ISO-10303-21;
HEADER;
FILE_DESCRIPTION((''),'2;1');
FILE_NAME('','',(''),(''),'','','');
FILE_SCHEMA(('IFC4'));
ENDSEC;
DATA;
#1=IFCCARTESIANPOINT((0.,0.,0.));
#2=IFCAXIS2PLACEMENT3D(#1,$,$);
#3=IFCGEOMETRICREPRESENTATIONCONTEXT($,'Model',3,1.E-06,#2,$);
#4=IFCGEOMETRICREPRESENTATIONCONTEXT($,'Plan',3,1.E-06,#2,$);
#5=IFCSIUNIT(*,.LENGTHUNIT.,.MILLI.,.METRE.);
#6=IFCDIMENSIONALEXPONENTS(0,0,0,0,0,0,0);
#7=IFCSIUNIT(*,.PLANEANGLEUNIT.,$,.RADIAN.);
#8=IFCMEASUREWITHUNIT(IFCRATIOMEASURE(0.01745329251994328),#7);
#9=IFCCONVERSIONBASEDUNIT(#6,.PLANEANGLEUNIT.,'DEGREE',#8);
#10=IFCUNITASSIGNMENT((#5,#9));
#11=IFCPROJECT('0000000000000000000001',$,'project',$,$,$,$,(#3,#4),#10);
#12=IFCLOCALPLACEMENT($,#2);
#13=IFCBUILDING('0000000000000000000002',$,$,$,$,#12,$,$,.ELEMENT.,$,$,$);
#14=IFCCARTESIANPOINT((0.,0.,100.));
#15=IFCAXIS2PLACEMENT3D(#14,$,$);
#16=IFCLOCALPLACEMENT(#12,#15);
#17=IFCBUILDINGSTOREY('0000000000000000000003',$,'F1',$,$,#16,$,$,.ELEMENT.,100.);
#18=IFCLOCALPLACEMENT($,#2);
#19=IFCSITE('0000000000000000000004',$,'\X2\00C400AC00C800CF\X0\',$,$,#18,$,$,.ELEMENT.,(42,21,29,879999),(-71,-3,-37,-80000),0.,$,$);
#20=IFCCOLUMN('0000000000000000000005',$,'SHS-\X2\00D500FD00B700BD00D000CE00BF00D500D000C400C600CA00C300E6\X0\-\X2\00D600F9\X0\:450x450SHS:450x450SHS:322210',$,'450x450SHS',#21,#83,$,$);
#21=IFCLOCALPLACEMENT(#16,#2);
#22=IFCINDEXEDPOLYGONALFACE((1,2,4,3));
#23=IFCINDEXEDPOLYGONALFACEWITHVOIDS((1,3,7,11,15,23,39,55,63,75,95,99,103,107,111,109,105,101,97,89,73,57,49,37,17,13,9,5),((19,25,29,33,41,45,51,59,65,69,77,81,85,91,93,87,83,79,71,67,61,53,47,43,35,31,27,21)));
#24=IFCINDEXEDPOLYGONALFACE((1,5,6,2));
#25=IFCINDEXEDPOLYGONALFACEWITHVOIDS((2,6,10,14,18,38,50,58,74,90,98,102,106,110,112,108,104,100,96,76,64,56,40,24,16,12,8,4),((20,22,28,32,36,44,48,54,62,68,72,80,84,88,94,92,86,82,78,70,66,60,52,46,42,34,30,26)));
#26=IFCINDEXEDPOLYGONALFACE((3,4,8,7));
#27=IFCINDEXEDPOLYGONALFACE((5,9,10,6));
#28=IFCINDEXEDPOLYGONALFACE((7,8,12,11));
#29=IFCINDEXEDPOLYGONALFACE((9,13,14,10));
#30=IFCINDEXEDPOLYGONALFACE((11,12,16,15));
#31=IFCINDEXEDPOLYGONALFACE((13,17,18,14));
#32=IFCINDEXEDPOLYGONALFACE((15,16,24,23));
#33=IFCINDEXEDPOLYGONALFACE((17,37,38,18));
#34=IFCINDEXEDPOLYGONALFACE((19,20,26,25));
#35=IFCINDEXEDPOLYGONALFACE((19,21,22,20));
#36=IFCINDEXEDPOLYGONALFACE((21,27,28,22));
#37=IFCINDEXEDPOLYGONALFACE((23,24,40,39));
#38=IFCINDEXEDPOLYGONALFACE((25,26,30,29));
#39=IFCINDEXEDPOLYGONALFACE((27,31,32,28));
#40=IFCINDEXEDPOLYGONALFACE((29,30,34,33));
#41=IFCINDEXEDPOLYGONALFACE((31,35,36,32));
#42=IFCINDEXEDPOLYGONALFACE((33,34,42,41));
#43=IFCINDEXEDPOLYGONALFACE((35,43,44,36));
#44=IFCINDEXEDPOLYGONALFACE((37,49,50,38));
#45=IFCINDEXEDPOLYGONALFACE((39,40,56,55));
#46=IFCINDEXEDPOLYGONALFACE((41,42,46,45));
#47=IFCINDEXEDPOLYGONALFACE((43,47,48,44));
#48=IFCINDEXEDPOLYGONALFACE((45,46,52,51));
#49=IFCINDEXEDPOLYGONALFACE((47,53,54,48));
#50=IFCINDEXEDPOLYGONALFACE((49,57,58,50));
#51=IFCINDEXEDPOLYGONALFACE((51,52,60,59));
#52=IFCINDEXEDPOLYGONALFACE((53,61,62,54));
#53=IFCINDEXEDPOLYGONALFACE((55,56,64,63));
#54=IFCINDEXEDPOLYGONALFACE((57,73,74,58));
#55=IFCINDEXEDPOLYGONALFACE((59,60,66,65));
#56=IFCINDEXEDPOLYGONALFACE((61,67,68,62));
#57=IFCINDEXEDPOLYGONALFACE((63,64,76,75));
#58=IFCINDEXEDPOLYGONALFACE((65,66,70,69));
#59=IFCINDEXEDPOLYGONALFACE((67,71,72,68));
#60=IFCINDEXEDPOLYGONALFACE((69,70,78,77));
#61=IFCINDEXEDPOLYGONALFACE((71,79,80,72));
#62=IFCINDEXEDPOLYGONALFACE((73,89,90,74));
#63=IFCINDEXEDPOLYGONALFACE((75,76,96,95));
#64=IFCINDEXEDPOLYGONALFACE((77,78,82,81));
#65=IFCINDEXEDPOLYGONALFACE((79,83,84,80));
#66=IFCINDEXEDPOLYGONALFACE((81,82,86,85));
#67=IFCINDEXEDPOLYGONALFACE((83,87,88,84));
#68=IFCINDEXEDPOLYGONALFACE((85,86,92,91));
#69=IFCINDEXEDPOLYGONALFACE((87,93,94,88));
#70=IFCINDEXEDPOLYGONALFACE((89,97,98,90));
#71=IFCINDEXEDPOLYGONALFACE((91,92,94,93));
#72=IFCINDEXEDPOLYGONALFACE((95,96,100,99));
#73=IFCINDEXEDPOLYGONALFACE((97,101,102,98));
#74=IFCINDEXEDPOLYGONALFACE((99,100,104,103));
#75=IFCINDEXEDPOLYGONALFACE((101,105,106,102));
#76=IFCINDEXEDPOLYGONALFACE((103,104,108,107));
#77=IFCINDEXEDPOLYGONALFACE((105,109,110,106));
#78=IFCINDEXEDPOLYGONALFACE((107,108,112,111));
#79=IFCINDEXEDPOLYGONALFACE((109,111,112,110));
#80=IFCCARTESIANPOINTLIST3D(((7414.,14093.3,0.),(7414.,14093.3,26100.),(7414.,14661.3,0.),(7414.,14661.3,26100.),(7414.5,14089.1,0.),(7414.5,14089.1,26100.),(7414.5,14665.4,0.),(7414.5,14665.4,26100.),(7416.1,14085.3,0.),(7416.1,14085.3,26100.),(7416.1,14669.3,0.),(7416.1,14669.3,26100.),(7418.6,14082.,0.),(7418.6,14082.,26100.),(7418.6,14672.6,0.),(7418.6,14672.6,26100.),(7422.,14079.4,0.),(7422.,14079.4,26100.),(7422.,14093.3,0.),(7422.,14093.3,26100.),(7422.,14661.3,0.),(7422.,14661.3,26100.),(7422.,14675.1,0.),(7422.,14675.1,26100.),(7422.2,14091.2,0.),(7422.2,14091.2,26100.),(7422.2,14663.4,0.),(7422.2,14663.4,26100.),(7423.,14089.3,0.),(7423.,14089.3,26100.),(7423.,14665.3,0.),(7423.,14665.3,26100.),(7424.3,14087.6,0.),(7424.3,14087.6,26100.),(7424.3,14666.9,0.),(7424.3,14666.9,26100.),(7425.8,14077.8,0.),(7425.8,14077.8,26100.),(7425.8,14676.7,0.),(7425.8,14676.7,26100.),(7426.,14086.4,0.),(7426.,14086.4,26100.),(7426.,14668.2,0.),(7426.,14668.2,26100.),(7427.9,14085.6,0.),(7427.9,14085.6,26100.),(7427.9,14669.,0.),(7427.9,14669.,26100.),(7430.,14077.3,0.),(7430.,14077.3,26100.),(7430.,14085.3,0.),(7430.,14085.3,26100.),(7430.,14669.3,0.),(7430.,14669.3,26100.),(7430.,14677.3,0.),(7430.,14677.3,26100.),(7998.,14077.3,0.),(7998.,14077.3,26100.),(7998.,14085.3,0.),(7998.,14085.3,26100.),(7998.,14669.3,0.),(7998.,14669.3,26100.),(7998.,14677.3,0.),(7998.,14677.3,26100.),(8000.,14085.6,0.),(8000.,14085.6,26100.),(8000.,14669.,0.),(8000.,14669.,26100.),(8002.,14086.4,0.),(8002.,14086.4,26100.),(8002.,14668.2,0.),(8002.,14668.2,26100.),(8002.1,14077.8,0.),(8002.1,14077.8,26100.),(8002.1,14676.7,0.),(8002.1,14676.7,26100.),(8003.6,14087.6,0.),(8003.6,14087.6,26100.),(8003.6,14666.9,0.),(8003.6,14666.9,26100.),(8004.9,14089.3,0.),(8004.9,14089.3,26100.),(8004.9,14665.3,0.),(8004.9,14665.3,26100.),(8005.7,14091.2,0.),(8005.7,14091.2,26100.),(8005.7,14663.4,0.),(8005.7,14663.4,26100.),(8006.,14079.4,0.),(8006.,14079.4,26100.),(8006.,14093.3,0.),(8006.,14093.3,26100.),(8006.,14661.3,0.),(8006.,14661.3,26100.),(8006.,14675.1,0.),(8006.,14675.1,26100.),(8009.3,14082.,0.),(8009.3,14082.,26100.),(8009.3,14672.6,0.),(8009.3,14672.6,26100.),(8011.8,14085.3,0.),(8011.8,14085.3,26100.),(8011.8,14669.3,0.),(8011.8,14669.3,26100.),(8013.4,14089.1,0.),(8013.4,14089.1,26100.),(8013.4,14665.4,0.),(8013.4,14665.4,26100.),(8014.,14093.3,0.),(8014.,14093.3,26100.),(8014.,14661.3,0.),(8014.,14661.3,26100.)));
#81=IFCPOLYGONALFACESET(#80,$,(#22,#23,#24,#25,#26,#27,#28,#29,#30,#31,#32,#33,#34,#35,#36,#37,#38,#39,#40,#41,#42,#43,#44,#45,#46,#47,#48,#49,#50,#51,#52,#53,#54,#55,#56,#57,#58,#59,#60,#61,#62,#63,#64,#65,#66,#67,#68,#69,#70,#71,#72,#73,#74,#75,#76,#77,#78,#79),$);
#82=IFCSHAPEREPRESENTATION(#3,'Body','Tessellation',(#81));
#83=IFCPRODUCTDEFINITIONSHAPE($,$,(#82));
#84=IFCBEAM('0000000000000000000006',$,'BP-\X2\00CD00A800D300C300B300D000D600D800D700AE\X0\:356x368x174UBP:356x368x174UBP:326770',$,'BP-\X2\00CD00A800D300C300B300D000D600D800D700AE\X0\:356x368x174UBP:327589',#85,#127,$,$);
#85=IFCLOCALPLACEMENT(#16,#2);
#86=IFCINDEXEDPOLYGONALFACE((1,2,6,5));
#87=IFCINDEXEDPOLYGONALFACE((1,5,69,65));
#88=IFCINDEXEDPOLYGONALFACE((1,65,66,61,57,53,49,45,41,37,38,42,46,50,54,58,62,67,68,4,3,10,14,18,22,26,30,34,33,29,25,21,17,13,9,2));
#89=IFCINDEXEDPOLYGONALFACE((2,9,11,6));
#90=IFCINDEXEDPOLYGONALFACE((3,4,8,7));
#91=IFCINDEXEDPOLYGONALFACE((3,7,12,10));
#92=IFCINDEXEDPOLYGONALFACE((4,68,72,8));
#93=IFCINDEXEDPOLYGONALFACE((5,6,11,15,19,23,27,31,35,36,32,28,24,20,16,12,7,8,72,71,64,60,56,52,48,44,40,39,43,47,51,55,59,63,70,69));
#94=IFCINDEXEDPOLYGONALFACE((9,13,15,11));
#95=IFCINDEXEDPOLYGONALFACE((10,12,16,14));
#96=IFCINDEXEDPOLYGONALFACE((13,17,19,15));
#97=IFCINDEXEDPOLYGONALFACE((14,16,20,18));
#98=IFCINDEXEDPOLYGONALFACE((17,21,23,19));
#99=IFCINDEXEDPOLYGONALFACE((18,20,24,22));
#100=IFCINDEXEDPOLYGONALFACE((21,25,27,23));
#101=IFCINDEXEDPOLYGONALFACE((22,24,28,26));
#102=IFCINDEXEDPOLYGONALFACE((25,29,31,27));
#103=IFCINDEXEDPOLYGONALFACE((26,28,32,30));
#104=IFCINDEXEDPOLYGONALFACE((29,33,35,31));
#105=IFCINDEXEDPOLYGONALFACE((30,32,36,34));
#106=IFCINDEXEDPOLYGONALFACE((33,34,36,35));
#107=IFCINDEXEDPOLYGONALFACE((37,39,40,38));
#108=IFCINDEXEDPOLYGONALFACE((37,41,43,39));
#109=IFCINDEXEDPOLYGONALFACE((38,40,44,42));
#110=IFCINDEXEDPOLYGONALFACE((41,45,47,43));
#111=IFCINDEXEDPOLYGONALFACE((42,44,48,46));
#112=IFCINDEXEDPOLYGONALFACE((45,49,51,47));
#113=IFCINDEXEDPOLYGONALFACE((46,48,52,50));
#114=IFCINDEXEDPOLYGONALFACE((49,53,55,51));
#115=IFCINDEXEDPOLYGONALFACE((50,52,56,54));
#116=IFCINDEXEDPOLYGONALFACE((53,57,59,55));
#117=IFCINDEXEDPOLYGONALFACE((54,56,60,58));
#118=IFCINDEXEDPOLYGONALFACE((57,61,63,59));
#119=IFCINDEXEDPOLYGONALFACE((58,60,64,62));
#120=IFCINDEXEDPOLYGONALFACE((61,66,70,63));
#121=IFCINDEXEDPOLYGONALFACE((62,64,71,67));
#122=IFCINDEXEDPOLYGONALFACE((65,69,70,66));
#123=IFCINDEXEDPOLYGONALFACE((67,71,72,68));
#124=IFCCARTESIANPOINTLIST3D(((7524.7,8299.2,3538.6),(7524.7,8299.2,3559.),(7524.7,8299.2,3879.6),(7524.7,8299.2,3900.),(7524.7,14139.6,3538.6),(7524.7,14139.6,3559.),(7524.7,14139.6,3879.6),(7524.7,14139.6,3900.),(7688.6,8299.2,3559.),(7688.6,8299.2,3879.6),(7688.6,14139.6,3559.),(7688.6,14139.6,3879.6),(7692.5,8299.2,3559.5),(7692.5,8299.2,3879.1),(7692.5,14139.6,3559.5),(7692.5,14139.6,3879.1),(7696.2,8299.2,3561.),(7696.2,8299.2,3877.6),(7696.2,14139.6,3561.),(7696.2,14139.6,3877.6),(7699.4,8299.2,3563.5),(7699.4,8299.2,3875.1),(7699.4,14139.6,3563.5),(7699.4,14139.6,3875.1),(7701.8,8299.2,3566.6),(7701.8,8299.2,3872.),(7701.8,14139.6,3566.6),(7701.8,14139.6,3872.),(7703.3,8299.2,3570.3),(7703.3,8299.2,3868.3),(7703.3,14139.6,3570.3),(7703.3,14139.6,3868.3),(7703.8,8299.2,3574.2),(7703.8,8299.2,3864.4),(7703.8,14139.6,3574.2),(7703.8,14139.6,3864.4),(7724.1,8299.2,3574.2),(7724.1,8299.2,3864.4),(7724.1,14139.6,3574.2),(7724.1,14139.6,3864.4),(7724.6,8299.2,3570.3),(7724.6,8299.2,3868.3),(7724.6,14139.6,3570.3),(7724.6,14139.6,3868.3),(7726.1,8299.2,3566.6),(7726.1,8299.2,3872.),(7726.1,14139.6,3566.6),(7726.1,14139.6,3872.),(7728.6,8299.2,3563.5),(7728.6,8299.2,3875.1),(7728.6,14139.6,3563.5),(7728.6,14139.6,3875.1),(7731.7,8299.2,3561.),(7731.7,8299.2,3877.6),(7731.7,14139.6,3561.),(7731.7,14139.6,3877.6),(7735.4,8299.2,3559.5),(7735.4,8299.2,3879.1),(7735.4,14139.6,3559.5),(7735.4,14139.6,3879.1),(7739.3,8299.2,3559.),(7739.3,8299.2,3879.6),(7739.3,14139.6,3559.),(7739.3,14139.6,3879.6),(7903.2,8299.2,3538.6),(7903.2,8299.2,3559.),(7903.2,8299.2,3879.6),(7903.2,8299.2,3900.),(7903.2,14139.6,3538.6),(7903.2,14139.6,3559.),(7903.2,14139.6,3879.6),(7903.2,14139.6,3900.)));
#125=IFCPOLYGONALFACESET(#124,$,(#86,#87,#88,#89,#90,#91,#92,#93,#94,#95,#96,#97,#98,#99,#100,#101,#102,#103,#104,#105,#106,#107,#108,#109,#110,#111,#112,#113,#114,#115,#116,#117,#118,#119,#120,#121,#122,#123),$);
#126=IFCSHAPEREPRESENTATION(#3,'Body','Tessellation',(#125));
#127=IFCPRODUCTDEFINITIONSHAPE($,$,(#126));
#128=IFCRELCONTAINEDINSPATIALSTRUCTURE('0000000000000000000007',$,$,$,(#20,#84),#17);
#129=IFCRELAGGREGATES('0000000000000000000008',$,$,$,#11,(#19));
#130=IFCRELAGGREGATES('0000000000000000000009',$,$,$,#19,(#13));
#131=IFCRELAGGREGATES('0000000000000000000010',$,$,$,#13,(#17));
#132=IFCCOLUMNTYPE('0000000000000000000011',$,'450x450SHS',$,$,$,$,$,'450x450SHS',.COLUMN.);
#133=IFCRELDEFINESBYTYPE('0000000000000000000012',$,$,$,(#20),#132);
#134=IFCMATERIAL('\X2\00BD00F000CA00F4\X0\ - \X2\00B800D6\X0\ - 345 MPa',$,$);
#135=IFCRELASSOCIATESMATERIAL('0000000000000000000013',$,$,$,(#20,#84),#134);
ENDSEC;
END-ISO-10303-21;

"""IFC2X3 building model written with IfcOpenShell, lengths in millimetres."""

from ifc_helpers import new_model, entity, si_unit, converted_unit, frame, frame_2d, origin, place, context, project, spatial, polyline, circle_curve, parameter, trimmed, segment, composite_curve, outline, extrude, source, transform, mapped, material, type_object, type_shapes, element, save


model = new_model("IFC2X3")

# Units and contexts
model_context = context("Model", 3, precision=1e-06, world=origin())
plan_context = context("Plan", 3, precision=1e-06, world=origin())
ifc_project = project(units=[si_unit("LENGTHUNIT", "METRE", prefix="MILLI"), converted_unit("PLANEANGLEUNIT", "DEGREE", entity("IfcRatioMeasure", 0.01745329251994328), si_unit("PLANEANGLEUNIT", "RADIAN"), dimensions=[0, 0, 0, 0, 0, 0, 0])], contexts=[model_context, plan_context])

# Site, building, storey
site_placement = place(None, origin())
site = spatial("IfcSite", under=ifc_project, at=site_placement, Name="Ä¬ÈÏ", CompositionType="ELEMENT", RefLatitude=(42, 21, 29, 879999), RefLongitude=(-71, -3, -37, -80000), RefElevation=0.0)
building_placement = place(None, origin())
building = spatial("IfcBuilding", under=site, at=building_placement, CompositionType="ELEMENT")
storey_placement = place(building_placement, frame((0.0, 0.0, 100.0)))
storey = spatial("IfcBuildingStorey", under=building, at=storey_placement, Name="F1", CompositionType="ELEMENT", Elevation=100.0)

# Column
ifc_material_1 = material(Name="½ðÊô - ¸Ö - 345 MPa")
column_type = type_object("IfcColumnType", Name="450x450SHS", ElementType="450x450SHS", PredefinedType="COLUMN")
shared_shape_1 = source(origin(), model_context, "Body", "SweptSolid", [
    extrude(outline(composite_curve([segment(polyline([(-284.0, -300.0), (284.0, -300.0)]), True, "CONTINUOUS"), segment(trimmed(circle_curve(frame_2d((284.0, -284.0), x_axis=(-1.0, 0.0)), 16.0), [parameter(90.0)], [parameter(180.0)], True, "PARAMETER"), True, "CONTINUOUS"), segment(polyline([(300.0, -284.0), (300.0, 284.0)]), True, "CONTINUOUS"), segment(trimmed(circle_curve(frame_2d((284.0, 284.0), x_axis=(-1.0, 0.0)), 16.0), [parameter(180.0)], [parameter(270.0)], True, "PARAMETER"), True, "CONTINUOUS"), segment(polyline([(284.0, 300.0), (-284.0, 300.0)]), True, "CONTINUOUS"), segment(trimmed(circle_curve(frame_2d((-284.0, 284.0), x_axis=(-1.0, 0.0)), 16.0), [parameter(270.0)], [parameter(360.0)], True, "PARAMETER"), True, "CONTINUOUS"), segment(polyline([(-300.0, 284.0), (-300.0, -284.0)]), True, "CONTINUOUS"), segment(trimmed(circle_curve(frame_2d((-284.0, -284.0), x_axis=(-1.0, 0.0)), 16.0), [parameter(360.0)], [parameter(90.0)], True, "PARAMETER"), True, "CONTINUOUS")], self_intersect=False), holes=[composite_curve([segment(trimmed(circle_curve(frame_2d((-284.0, -284.0), x_axis=(-1.0, 0.0)), 8.0), [parameter(0.0)], [parameter(90.0)], True, "PARAMETER"), False, "CONTINUOUS"), segment(polyline([(-292.0, -284.0), (-292.0, 284.0)]), True, "CONTINUOUS"), segment(trimmed(circle_curve(frame_2d((-284.0, 284.0), x_axis=(-1.0, 0.0)), 8.0), [parameter(270.0)], [parameter(360.0)], True, "PARAMETER"), False, "CONTINUOUS"), segment(polyline([(-284.0, 292.0), (284.0, 292.0)]), True, "CONTINUOUS"), segment(trimmed(circle_curve(frame_2d((284.0, 284.0), x_axis=(-1.0, 0.0)), 8.0), [parameter(180.0)], [parameter(270.0)], True, "PARAMETER"), False, "CONTINUOUS"), segment(polyline([(292.0, 284.0), (292.0, -284.0)]), True, "CONTINUOUS"), segment(trimmed(circle_curve(frame_2d((284.0, -284.0), x_axis=(-1.0, 0.0)), 8.0), [parameter(90.0)], [parameter(180.0)], True, "PARAMETER"), False, "CONTINUOUS"), segment(polyline([(284.0, -292.0), (-284.0, -292.0)]), True, "CONTINUOUS")], self_intersect=False)]), frame((0.0, 0.0, 100.0), z_axis=(0.0, 0.0, 1.0), x_axis=(-1.0, 0.0, 0.0)), (0.0, 0.0, 1.0), 26100.0),
])
type_shapes(column_type, [shared_shape_1])
column_placement = place(storey_placement, frame((7714.0, 14377.3, -100.0)))
element("IfcColumn", 1, at=column_placement, inside=storey, type_object=column_type, material=ifc_material_1, Name="SHS-Õý·½ÐÎ¿ÕÐÄÆÊÃæ-Öù:450x450SHS:450x450SHS:322210", ObjectType="450x450SHS", context=model_context, shape_type="MappedRepresentation", body=[
    mapped(shared_shape_1, transform((0.0, 0.0, 0.0), scale=1.0)),
])

# Beam
beam_placement = place(storey_placement, frame((7714.0, 14377.3, 3900.0), z_axis=(0.0, 0.0, 1.0), x_axis=(-1.0, 0.0, 0.0)))
element("IfcBeam", 2, at=beam_placement, inside=storey, material=ifc_material_1, Name="BP-Í¨ÓÃ³ÐÖØ×®:356x368x174UBP:356x368x174UBP:326770", ObjectType="BP-Í¨ÓÃ³ÐÖØ×®:356x368x174UBP:327589", context=model_context, shape_type="SweptSolid", body=[
    extrude(outline(composite_curve([segment(polyline([(160.3, -189.3), (180.7, -189.3)]), True, "CONTINUOUS"), segment(polyline([(180.7, -189.3), (180.7, 189.2)]), True, "CONTINUOUS"), segment(polyline([(180.7, 189.2), (160.3, 189.2)]), True, "CONTINUOUS"), segment(polyline([(160.3, 189.2), (160.3, 25.3)]), True, "CONTINUOUS"), segment(trimmed(circle_curve(frame_2d((145.1, 25.3), x_axis=(0.0, 1.0)), 15.2), [parameter(180.0)], [parameter(270.0)], True, "PARAMETER"), False, "CONTINUOUS"), segment(polyline([(145.1, 10.1), (-145.1, 10.1)]), True, "CONTINUOUS"), segment(trimmed(circle_curve(frame_2d((-145.1, 25.3), x_axis=(0.0, 1.0)), 15.2), [parameter(90.0)], [parameter(180.0)], True, "PARAMETER"), False, "CONTINUOUS"), segment(polyline([(-160.3, 25.3), (-160.3, 189.2)]), True, "CONTINUOUS"), segment(polyline([(-160.3, 189.2), (-180.7, 189.2)]), True, "CONTINUOUS"), segment(polyline([(-180.7, 189.2), (-180.7, -189.3)]), True, "CONTINUOUS"), segment(polyline([(-180.7, -189.3), (-160.3, -189.3)]), True, "CONTINUOUS"), segment(polyline([(-160.3, -189.3), (-160.3, -25.4)]), True, "CONTINUOUS"), segment(trimmed(circle_curve(frame_2d((-145.1, -25.4), x_axis=(0.0, 1.0)), 15.2), [parameter(360.0)], [parameter(90.0)], True, "PARAMETER"), False, "CONTINUOUS"), segment(polyline([(-145.1, -10.2), (145.1, -10.2)]), True, "CONTINUOUS"), segment(trimmed(circle_curve(frame_2d((145.1, -25.4), x_axis=(0.0, 1.0)), 15.2), [parameter(270.0)], [parameter(360.0)], True, "PARAMETER"), False, "CONTINUOUS"), segment(polyline([(160.3, -25.4), (160.3, -189.3)]), True, "CONTINUOUS")], self_intersect=False)), frame((0.0, 6078.0, -180.7), z_axis=(0.0, -1.0, 0.0), x_axis=(0.0, 0.0, -1.0)), (0.0, 0.0, 1.0), 5840.3),
])

save(model, "model.ifc")
